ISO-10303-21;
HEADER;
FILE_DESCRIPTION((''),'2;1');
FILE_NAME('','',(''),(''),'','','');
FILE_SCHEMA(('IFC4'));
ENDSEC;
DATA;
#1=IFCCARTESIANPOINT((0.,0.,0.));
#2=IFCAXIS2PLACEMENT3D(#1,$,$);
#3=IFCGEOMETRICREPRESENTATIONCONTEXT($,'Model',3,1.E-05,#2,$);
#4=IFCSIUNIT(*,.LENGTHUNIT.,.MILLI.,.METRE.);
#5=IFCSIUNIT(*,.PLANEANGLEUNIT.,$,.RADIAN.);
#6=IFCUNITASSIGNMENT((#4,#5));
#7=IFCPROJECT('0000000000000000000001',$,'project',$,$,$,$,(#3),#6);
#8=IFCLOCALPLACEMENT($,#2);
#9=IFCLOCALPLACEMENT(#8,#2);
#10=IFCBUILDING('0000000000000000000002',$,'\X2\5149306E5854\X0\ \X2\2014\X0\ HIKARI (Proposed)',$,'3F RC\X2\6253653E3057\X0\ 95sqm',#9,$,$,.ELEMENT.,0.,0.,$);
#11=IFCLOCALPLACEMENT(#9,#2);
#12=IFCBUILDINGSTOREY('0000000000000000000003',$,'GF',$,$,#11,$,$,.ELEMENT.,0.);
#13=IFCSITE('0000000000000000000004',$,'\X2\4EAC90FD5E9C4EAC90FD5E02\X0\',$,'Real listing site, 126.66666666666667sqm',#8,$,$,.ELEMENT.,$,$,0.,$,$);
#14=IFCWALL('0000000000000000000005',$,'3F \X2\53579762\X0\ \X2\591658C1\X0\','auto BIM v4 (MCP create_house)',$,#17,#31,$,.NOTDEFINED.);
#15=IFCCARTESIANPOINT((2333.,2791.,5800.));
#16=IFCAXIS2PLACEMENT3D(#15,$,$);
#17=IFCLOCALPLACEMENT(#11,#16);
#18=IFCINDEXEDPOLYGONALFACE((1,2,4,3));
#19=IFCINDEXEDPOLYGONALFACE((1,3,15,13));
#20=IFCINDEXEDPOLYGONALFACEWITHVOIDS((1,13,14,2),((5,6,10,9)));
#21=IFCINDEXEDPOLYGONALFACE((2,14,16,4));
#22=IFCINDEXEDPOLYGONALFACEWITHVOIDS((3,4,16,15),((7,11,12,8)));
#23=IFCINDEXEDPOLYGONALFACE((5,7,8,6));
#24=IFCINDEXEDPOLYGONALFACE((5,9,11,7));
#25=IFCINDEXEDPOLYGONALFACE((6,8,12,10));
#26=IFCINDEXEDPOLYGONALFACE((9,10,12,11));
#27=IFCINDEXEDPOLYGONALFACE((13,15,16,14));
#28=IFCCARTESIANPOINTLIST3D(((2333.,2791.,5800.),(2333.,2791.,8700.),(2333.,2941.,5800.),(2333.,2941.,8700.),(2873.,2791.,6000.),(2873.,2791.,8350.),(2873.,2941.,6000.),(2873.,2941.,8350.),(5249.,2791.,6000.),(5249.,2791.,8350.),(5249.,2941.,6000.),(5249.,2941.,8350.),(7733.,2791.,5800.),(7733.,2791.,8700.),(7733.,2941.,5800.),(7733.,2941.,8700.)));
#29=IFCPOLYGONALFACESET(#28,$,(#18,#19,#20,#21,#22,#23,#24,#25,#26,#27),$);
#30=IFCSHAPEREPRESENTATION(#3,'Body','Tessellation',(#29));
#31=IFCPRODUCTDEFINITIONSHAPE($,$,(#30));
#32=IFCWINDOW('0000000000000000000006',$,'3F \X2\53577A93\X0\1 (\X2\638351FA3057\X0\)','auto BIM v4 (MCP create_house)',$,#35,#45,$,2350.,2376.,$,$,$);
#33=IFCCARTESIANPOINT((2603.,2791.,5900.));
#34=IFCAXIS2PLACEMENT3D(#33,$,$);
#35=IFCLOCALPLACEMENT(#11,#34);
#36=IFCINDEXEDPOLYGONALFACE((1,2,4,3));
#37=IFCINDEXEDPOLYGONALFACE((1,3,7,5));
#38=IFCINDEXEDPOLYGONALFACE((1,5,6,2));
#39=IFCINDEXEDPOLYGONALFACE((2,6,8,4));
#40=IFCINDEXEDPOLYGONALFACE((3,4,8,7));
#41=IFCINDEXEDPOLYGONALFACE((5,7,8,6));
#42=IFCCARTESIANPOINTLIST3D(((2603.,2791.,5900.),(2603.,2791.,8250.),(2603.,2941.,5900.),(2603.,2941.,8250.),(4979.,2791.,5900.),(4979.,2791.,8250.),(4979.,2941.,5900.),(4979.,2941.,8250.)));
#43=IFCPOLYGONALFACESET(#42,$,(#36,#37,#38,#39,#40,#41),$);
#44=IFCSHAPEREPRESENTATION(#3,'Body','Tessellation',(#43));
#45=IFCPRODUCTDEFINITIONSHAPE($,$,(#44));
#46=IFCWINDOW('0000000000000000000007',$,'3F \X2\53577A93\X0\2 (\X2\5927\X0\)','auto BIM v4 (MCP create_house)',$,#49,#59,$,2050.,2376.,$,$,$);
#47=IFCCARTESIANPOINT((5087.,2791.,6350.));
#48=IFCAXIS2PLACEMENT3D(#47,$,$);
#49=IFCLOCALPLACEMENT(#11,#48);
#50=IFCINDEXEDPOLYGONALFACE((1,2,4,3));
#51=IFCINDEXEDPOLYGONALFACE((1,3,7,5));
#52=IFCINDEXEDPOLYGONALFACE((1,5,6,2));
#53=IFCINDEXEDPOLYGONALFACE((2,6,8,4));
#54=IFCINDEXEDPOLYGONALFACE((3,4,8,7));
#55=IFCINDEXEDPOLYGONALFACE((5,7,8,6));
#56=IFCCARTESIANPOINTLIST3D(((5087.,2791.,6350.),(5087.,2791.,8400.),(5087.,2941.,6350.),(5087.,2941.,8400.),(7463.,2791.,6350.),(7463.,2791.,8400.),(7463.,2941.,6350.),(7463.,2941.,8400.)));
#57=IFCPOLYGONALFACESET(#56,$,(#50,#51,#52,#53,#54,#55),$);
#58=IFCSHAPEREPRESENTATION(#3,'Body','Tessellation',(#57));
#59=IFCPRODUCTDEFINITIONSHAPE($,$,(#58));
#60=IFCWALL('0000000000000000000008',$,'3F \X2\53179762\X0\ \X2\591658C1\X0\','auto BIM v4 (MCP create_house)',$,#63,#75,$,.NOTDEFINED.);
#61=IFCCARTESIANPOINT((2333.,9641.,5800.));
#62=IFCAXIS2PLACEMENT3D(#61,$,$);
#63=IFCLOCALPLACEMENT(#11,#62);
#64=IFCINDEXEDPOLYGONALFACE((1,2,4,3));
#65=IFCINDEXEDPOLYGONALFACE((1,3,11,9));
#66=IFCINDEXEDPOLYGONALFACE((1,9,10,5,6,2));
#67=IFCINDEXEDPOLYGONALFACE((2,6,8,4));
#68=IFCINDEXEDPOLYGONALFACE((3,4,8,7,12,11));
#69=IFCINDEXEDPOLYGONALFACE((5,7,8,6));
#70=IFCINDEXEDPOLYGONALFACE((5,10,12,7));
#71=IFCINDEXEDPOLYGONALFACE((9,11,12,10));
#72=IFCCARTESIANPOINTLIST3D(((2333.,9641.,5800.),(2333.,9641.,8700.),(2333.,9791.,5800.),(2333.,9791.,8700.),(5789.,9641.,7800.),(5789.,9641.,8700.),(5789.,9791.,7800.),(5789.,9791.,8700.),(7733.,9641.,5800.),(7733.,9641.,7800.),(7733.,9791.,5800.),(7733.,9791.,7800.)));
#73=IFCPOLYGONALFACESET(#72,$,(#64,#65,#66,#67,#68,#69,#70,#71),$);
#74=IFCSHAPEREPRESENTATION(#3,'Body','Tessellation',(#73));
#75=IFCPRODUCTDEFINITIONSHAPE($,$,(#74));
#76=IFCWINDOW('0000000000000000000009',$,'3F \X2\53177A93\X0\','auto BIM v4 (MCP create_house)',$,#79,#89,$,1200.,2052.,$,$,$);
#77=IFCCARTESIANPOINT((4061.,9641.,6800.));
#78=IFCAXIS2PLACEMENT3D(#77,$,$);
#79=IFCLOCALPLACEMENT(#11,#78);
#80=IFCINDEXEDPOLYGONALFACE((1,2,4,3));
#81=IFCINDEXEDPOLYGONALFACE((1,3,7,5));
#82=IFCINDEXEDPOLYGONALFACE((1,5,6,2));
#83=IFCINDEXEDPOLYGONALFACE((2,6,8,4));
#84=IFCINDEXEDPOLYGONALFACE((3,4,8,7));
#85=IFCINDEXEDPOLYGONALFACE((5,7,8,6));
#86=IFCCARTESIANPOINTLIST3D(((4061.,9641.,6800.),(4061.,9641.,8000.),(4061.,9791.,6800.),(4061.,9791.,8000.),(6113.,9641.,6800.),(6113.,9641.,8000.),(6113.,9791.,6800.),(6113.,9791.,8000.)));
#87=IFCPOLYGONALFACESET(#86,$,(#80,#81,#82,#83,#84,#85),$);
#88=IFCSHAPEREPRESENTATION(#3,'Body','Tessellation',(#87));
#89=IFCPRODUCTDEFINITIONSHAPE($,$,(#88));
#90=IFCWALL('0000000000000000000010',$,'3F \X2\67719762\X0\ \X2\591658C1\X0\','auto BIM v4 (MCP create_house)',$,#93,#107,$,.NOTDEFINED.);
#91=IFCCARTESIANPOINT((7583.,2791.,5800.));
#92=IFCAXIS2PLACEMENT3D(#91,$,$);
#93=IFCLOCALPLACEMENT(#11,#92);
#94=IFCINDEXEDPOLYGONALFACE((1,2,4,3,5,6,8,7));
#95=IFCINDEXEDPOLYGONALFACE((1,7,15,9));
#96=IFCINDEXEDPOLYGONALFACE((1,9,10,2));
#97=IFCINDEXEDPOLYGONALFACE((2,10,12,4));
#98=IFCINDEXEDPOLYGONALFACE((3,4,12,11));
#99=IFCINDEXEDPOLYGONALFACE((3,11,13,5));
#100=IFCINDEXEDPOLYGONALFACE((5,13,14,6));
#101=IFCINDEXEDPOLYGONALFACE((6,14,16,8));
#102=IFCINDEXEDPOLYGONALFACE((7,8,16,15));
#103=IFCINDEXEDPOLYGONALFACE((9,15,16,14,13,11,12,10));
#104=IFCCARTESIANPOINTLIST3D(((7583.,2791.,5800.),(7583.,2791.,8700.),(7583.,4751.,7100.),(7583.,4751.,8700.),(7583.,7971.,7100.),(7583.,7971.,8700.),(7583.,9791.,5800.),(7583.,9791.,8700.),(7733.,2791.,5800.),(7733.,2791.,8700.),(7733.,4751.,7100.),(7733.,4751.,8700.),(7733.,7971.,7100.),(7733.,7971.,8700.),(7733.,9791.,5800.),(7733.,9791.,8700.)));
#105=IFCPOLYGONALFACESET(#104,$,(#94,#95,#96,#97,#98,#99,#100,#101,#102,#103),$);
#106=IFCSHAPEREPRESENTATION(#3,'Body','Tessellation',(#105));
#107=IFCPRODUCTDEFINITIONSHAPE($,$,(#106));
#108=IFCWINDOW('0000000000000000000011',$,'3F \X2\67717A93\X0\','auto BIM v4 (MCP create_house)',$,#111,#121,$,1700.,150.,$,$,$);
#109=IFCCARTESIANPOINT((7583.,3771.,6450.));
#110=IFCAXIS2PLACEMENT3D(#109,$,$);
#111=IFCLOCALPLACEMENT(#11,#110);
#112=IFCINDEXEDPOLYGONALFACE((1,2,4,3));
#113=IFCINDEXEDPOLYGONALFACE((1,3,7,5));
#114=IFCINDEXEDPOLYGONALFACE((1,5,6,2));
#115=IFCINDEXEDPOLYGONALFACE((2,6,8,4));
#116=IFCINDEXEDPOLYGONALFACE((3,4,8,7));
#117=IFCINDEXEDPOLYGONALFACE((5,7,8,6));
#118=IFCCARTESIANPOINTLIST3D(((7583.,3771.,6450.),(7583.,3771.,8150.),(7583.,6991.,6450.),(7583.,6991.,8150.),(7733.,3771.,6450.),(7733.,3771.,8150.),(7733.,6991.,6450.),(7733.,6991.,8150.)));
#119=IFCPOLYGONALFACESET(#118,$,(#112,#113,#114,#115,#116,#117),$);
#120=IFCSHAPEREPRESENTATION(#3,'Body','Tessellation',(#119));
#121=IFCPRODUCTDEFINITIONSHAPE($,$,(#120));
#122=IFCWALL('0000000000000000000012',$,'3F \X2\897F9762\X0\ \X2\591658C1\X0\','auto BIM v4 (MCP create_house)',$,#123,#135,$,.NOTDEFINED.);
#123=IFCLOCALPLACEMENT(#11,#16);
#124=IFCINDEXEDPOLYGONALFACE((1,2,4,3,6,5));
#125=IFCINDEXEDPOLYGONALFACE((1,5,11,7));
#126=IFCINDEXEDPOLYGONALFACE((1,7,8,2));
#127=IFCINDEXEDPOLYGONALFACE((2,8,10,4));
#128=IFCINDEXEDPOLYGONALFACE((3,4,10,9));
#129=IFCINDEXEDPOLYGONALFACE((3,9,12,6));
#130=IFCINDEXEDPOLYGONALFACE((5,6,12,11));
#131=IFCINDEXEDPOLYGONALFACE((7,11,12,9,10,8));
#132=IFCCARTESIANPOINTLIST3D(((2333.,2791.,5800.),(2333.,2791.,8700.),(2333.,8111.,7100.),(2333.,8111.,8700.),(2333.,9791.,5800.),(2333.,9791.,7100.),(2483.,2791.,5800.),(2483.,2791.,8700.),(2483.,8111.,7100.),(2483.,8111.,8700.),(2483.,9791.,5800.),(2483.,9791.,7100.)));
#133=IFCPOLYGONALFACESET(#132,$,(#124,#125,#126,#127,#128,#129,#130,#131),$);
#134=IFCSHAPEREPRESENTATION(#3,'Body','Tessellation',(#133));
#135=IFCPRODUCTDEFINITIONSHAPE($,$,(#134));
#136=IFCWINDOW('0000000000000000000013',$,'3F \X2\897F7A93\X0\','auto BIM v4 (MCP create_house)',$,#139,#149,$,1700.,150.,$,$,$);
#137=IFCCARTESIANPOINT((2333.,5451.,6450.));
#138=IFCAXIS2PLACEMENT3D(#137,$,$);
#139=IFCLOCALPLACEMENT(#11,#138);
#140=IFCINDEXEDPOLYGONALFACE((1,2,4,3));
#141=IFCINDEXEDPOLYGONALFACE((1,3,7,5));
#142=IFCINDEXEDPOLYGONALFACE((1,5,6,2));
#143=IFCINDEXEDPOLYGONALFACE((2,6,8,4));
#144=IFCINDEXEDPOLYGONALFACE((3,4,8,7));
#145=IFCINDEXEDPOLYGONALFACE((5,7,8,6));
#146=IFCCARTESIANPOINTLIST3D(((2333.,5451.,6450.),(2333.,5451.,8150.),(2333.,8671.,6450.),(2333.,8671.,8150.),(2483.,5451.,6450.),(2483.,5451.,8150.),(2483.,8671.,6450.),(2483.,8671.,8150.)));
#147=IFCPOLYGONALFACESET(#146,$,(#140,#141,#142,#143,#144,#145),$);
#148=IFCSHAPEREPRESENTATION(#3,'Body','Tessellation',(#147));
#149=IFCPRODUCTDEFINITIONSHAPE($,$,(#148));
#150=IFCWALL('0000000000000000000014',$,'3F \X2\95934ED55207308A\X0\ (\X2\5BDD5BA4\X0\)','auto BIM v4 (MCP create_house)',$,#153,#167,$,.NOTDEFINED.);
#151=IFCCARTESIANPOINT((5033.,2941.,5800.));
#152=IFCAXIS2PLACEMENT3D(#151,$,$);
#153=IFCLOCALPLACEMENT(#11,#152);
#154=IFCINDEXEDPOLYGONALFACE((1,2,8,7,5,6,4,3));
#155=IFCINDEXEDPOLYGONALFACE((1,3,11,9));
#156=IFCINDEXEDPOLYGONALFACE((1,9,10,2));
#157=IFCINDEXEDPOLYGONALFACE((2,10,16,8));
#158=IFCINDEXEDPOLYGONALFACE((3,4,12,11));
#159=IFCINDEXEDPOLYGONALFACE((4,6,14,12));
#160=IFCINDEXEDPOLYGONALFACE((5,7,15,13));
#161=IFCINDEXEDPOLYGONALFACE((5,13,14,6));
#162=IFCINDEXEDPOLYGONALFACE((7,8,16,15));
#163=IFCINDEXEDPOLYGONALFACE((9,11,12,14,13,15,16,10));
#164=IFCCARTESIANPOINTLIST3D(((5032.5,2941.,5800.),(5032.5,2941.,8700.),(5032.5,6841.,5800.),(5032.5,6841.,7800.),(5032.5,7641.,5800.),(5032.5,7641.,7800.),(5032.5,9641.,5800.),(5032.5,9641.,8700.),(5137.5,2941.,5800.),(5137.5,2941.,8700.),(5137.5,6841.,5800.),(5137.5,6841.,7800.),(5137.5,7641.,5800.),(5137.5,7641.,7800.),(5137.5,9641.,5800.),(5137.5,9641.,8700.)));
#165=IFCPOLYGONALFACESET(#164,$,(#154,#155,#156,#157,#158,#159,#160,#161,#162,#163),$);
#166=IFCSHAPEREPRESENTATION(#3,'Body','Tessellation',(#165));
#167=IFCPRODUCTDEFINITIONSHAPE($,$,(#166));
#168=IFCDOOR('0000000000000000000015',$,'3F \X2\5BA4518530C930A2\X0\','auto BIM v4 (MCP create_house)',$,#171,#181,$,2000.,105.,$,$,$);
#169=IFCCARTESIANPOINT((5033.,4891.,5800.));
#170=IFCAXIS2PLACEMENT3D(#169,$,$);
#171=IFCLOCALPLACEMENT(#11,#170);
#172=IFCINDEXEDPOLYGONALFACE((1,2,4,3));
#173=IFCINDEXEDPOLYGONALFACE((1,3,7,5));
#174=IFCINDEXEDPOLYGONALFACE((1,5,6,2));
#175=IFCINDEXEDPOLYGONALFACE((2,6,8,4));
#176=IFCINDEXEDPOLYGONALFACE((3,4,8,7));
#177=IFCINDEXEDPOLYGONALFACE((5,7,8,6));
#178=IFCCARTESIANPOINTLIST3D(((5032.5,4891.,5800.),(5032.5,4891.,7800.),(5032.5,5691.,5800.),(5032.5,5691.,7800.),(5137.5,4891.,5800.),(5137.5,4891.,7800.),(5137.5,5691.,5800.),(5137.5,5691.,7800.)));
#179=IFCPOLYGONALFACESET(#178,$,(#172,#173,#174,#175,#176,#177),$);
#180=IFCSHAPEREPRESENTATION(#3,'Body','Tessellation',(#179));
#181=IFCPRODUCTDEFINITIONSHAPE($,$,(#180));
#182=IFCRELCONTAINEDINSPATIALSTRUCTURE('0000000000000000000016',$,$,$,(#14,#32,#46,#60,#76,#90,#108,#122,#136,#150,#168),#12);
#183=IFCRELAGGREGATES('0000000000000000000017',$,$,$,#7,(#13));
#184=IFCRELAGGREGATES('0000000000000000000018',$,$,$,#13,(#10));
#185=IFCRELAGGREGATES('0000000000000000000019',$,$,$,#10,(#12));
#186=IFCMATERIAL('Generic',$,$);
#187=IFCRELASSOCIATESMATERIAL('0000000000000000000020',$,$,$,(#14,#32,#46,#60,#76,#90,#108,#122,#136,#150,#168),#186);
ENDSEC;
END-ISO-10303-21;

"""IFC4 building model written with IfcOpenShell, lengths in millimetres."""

from ifc_helpers import new_model, si_unit, frame, frame_2d, origin, place, context, project, spatial, rectangle, extrude, material, element, fill, save


model = new_model("IFC4")

# Units and contexts
model_context = context("Model", 3, precision=1e-05, world=origin())
ifc_project = project(units=[si_unit("LENGTHUNIT", "METRE", prefix="MILLI"), si_unit("PLANEANGLEUNIT", "RADIAN")], contexts=[model_context])

# Site, building, storey
site_placement = place(None, origin())
site = spatial("IfcSite", under=ifc_project, at=site_placement, Name="京都府京都市", ObjectType="Real listing site, 126.66666666666667sqm", CompositionType="ELEMENT", RefElevation=0.0)
building_placement = place(site_placement, origin())
building = spatial("IfcBuilding", under=site, at=building_placement, Name="光の塔 — HIKARI (Proposed)", ObjectType="3F RC打放し 95sqm", CompositionType="ELEMENT", ElevationOfRefHeight=0.0, ElevationOfTerrain=0.0)
storey_placement = place(building_placement, origin())
storey = spatial("IfcBuildingStorey", under=building, at=storey_placement, Name="GF", CompositionType="ELEMENT", Elevation=0.0)

# Shared definitions
ifc_material = material(Name="Generic")

# Wall, openings, windows
wall_1_placement = place(storey_placement, frame((2333.0, 2791.0, 5800.0)))
wall_1 = element("IfcWall", 1, at=wall_1_placement, inside=storey, material=ifc_material, Name="3F 南面 外壁", Description="auto BIM v4 (MCP create_house)", PredefinedType="NOTDEFINED", context=model_context, shape_type="SweptSolid", body=[
    extrude(rectangle(XDim=5400.0, YDim=150.0, at=frame_2d((2700.0, 75.0))), frame((2333.0, 2791.0, 5800.0)), (0.0, 0.0, 1.0), 2900.0),
])
opening_1_placement = place(storey_placement, frame((2603.0, 2791.0, 5900.0)))
opening_1 = element("IfcOpeningElement", 2, at=opening_1_placement, cuts=wall_1, PredefinedType="NOTDEFINED", context=model_context, shape_type="SweptSolid", body=[
    extrude(rectangle(XDim=2376.0, YDim=150.0, at=frame_2d((1188.0, 75.0))), frame((2603.0, 2791.0, 5900.0)), (0.0, 0.0, 1.0), 2350.0),
])
opening_2_placement = place(storey_placement, frame((5087.0, 2791.0, 6350.0)))
opening_2 = element("IfcOpeningElement", 3, at=opening_2_placement, cuts=wall_1, PredefinedType="NOTDEFINED", context=model_context, shape_type="SweptSolid", body=[
    extrude(rectangle(XDim=2376.0, YDim=150.0, at=frame_2d((1188.0, 75.0))), frame((5087.0, 2791.0, 6350.0)), (0.0, 0.0, 1.0), 2050.0),
])
window_1_placement = place(storey_placement, frame((2603.0, 2791.0, 5900.0)))
window_1 = element("IfcWindow", 4, at=window_1_placement, inside=storey, material=ifc_material, Name="3F 南窓1 (掃出し)", Description="auto BIM v4 (MCP create_house)", OverallHeight=2350.0, OverallWidth=2376.0, context=model_context, shape_type="SweptSolid", body=[
    extrude(rectangle(XDim=2376.0, YDim=150.0, at=frame_2d((1188.0, 75.0))), frame((2603.0, 2791.0, 5900.0)), (0.0, 0.0, 1.0), 2350.0),
])
fill(opening_1, window_1)
window_2_placement = place(storey_placement, frame((5087.0, 2791.0, 6350.0)))
window_2 = element("IfcWindow", 5, at=window_2_placement, inside=storey, material=ifc_material, Name="3F 南窓2 (大)", Description="auto BIM v4 (MCP create_house)", OverallHeight=2050.0, OverallWidth=2376.0, context=model_context, shape_type="SweptSolid", body=[
    extrude(rectangle(XDim=2376.0, YDim=150.0, at=frame_2d((1188.0, 75.0))), frame((5087.0, 2791.0, 6350.0)), (0.0, 0.0, 1.0), 2050.0),
])
fill(opening_2, window_2)

# Walls, openings, windows
wall_2_placement = place(storey_placement, frame((2333.0, 9641.0, 5800.0)))
wall_2 = element("IfcWall", 6, at=wall_2_placement, inside=storey, material=ifc_material, Name="3F 北面 外壁", Description="auto BIM v4 (MCP create_house)", PredefinedType="NOTDEFINED", context=model_context, shape_type="SweptSolid", body=[
    extrude(rectangle(XDim=5400.0, YDim=150.0, at=frame_2d((2700.0, 75.0))), frame((2333.0, 9641.0, 5800.0)), (0.0, 0.0, 1.0), 2900.0),
])
opening_3_placement = place(storey_placement, frame((4061.0, 9641.0, 6800.0)))
opening_3 = element("IfcOpeningElement", 7, at=opening_3_placement, cuts=wall_2, PredefinedType="NOTDEFINED", context=model_context, shape_type="SweptSolid", body=[
    extrude(rectangle(XDim=2052.0, YDim=150.0, at=frame_2d((1026.0, 75.0))), frame((4061.0, 9641.0, 6800.0)), (0.0, 0.0, 1.0), 1200.0),
])
window_3_placement = place(storey_placement, frame((4061.0, 9641.0, 6800.0)))
window_3 = element("IfcWindow", 8, at=window_3_placement, inside=storey, material=ifc_material, Name="3F 北窓", Description="auto BIM v4 (MCP create_house)", OverallHeight=1200.0, OverallWidth=2052.0, context=model_context, shape_type="SweptSolid", body=[
    extrude(rectangle(XDim=2052.0, YDim=150.0, at=frame_2d((1026.0, 75.0))), frame((4061.0, 9641.0, 6800.0)), (0.0, 0.0, 1.0), 1200.0),
])
fill(opening_3, window_3)
wall_3_placement = place(storey_placement, frame((7583.0, 2791.0, 5800.0)))
wall_3 = element("IfcWall", 9, at=wall_3_placement, inside=storey, material=ifc_material, Name="3F 東面 外壁", Description="auto BIM v4 (MCP create_house)", PredefinedType="NOTDEFINED", context=model_context, shape_type="SweptSolid", body=[
    extrude(rectangle(XDim=150.0, YDim=7000.0, at=frame_2d((75.0, 3500.0))), frame((7583.0, 2791.0, 5800.0)), (0.0, 0.0, 1.0), 2900.0),
])
opening_4_placement = place(storey_placement, frame((7583.0, 3771.0, 6450.0)))
opening_4 = element("IfcOpeningElement", 10, at=opening_4_placement, cuts=wall_3, PredefinedType="NOTDEFINED", context=model_context, shape_type="SweptSolid", body=[
    extrude(rectangle(XDim=150.0, YDim=3220.0, at=frame_2d((75.0, 1610.0))), frame((7583.0, 3771.0, 6450.0)), (0.0, 0.0, 1.0), 1700.0),
])
window_4_placement = place(storey_placement, frame((7583.0, 3771.0, 6450.0)))
window_4 = element("IfcWindow", 11, at=window_4_placement, inside=storey, material=ifc_material, Name="3F 東窓", Description="auto BIM v4 (MCP create_house)", OverallHeight=1700.0, OverallWidth=150.0, context=model_context, shape_type="SweptSolid", body=[
    extrude(rectangle(XDim=150.0, YDim=3220.0, at=frame_2d((75.0, 1610.0))), frame((7583.0, 3771.0, 6450.0)), (0.0, 0.0, 1.0), 1700.0),
])
fill(opening_4, window_4)
wall_4_placement = place(storey_placement, frame((2333.0, 2791.0, 5800.0)))
wall_4 = element("IfcWall", 12, at=wall_4_placement, inside=storey, material=ifc_material, Name="3F 西面 外壁", Description="auto BIM v4 (MCP create_house)", PredefinedType="NOTDEFINED", context=model_context, shape_type="SweptSolid", body=[
    extrude(rectangle(XDim=150.0, YDim=7000.0, at=frame_2d((75.0, 3500.0))), frame((2333.0, 2791.0, 5800.0)), (0.0, 0.0, 1.0), 2900.0),
])
opening_5_placement = place(storey_placement, frame((2333.0, 5451.0, 6450.0)))
opening_5 = element("IfcOpeningElement", 13, at=opening_5_placement, cuts=wall_4, PredefinedType="NOTDEFINED", context=model_context, shape_type="SweptSolid", body=[
    extrude(rectangle(XDim=150.0, YDim=3220.0, at=frame_2d((75.0, 1610.0))), frame((2333.0, 5451.0, 6450.0)), (0.0, 0.0, 1.0), 1700.0),
])
window_5_placement = place(storey_placement, frame((2333.0, 5451.0, 6450.0)))
window_5 = element("IfcWindow", 14, at=window_5_placement, inside=storey, material=ifc_material, Name="3F 西窓", Description="auto BIM v4 (MCP create_house)", OverallHeight=1700.0, OverallWidth=150.0, context=model_context, shape_type="SweptSolid", body=[
    extrude(rectangle(XDim=150.0, YDim=3220.0, at=frame_2d((75.0, 1610.0))), frame((2333.0, 5451.0, 6450.0)), (0.0, 0.0, 1.0), 1700.0),
])
fill(opening_5, window_5)

# Wall, opening, door
wall_5_placement = place(storey_placement, frame((5033.0, 2941.0, 5800.0)))
wall_5 = element("IfcWall", 15, at=wall_5_placement, inside=storey, material=ifc_material, Name="3F 間仕切り (寝室)", Description="auto BIM v4 (MCP create_house)", PredefinedType="NOTDEFINED", context=model_context, shape_type="SweptSolid", body=[
    extrude(rectangle(XDim=105.0, YDim=6700.0, at=frame_2d((52.0, 3350.0))), frame((5033.0, 2941.0, 5800.0)), (0.0, 0.0, 1.0), 2900.0),
])
opening_6_placement = place(storey_placement, frame((5033.0, 4891.0, 5800.0)))
opening_6 = element("IfcOpeningElement", 16, at=opening_6_placement, cuts=wall_5, PredefinedType="NOTDEFINED", context=model_context, shape_type="SweptSolid", body=[
    extrude(rectangle(XDim=105.0, YDim=800.0, at=frame_2d((52.0, 400.0))), frame((5033.0, 4891.0, 5800.0)), (0.0, 0.0, 1.0), 2000.0),
])
door_1_placement = place(storey_placement, frame((5033.0, 4891.0, 5800.0)))
door_1 = element("IfcDoor", 17, at=door_1_placement, inside=storey, material=ifc_material, Name="3F 室内ドア", Description="auto BIM v4 (MCP create_house)", OverallHeight=2000.0, OverallWidth=105.0, context=model_context, shape_type="SweptSolid", body=[
    extrude(rectangle(XDim=105.0, YDim=800.0, at=frame_2d((52.0, 400.0))), frame((5033.0, 4891.0, 5800.0)), (0.0, 0.0, 1.0), 2000.0),
])
fill(opening_6, door_1)

save(model, "model.ifc")
